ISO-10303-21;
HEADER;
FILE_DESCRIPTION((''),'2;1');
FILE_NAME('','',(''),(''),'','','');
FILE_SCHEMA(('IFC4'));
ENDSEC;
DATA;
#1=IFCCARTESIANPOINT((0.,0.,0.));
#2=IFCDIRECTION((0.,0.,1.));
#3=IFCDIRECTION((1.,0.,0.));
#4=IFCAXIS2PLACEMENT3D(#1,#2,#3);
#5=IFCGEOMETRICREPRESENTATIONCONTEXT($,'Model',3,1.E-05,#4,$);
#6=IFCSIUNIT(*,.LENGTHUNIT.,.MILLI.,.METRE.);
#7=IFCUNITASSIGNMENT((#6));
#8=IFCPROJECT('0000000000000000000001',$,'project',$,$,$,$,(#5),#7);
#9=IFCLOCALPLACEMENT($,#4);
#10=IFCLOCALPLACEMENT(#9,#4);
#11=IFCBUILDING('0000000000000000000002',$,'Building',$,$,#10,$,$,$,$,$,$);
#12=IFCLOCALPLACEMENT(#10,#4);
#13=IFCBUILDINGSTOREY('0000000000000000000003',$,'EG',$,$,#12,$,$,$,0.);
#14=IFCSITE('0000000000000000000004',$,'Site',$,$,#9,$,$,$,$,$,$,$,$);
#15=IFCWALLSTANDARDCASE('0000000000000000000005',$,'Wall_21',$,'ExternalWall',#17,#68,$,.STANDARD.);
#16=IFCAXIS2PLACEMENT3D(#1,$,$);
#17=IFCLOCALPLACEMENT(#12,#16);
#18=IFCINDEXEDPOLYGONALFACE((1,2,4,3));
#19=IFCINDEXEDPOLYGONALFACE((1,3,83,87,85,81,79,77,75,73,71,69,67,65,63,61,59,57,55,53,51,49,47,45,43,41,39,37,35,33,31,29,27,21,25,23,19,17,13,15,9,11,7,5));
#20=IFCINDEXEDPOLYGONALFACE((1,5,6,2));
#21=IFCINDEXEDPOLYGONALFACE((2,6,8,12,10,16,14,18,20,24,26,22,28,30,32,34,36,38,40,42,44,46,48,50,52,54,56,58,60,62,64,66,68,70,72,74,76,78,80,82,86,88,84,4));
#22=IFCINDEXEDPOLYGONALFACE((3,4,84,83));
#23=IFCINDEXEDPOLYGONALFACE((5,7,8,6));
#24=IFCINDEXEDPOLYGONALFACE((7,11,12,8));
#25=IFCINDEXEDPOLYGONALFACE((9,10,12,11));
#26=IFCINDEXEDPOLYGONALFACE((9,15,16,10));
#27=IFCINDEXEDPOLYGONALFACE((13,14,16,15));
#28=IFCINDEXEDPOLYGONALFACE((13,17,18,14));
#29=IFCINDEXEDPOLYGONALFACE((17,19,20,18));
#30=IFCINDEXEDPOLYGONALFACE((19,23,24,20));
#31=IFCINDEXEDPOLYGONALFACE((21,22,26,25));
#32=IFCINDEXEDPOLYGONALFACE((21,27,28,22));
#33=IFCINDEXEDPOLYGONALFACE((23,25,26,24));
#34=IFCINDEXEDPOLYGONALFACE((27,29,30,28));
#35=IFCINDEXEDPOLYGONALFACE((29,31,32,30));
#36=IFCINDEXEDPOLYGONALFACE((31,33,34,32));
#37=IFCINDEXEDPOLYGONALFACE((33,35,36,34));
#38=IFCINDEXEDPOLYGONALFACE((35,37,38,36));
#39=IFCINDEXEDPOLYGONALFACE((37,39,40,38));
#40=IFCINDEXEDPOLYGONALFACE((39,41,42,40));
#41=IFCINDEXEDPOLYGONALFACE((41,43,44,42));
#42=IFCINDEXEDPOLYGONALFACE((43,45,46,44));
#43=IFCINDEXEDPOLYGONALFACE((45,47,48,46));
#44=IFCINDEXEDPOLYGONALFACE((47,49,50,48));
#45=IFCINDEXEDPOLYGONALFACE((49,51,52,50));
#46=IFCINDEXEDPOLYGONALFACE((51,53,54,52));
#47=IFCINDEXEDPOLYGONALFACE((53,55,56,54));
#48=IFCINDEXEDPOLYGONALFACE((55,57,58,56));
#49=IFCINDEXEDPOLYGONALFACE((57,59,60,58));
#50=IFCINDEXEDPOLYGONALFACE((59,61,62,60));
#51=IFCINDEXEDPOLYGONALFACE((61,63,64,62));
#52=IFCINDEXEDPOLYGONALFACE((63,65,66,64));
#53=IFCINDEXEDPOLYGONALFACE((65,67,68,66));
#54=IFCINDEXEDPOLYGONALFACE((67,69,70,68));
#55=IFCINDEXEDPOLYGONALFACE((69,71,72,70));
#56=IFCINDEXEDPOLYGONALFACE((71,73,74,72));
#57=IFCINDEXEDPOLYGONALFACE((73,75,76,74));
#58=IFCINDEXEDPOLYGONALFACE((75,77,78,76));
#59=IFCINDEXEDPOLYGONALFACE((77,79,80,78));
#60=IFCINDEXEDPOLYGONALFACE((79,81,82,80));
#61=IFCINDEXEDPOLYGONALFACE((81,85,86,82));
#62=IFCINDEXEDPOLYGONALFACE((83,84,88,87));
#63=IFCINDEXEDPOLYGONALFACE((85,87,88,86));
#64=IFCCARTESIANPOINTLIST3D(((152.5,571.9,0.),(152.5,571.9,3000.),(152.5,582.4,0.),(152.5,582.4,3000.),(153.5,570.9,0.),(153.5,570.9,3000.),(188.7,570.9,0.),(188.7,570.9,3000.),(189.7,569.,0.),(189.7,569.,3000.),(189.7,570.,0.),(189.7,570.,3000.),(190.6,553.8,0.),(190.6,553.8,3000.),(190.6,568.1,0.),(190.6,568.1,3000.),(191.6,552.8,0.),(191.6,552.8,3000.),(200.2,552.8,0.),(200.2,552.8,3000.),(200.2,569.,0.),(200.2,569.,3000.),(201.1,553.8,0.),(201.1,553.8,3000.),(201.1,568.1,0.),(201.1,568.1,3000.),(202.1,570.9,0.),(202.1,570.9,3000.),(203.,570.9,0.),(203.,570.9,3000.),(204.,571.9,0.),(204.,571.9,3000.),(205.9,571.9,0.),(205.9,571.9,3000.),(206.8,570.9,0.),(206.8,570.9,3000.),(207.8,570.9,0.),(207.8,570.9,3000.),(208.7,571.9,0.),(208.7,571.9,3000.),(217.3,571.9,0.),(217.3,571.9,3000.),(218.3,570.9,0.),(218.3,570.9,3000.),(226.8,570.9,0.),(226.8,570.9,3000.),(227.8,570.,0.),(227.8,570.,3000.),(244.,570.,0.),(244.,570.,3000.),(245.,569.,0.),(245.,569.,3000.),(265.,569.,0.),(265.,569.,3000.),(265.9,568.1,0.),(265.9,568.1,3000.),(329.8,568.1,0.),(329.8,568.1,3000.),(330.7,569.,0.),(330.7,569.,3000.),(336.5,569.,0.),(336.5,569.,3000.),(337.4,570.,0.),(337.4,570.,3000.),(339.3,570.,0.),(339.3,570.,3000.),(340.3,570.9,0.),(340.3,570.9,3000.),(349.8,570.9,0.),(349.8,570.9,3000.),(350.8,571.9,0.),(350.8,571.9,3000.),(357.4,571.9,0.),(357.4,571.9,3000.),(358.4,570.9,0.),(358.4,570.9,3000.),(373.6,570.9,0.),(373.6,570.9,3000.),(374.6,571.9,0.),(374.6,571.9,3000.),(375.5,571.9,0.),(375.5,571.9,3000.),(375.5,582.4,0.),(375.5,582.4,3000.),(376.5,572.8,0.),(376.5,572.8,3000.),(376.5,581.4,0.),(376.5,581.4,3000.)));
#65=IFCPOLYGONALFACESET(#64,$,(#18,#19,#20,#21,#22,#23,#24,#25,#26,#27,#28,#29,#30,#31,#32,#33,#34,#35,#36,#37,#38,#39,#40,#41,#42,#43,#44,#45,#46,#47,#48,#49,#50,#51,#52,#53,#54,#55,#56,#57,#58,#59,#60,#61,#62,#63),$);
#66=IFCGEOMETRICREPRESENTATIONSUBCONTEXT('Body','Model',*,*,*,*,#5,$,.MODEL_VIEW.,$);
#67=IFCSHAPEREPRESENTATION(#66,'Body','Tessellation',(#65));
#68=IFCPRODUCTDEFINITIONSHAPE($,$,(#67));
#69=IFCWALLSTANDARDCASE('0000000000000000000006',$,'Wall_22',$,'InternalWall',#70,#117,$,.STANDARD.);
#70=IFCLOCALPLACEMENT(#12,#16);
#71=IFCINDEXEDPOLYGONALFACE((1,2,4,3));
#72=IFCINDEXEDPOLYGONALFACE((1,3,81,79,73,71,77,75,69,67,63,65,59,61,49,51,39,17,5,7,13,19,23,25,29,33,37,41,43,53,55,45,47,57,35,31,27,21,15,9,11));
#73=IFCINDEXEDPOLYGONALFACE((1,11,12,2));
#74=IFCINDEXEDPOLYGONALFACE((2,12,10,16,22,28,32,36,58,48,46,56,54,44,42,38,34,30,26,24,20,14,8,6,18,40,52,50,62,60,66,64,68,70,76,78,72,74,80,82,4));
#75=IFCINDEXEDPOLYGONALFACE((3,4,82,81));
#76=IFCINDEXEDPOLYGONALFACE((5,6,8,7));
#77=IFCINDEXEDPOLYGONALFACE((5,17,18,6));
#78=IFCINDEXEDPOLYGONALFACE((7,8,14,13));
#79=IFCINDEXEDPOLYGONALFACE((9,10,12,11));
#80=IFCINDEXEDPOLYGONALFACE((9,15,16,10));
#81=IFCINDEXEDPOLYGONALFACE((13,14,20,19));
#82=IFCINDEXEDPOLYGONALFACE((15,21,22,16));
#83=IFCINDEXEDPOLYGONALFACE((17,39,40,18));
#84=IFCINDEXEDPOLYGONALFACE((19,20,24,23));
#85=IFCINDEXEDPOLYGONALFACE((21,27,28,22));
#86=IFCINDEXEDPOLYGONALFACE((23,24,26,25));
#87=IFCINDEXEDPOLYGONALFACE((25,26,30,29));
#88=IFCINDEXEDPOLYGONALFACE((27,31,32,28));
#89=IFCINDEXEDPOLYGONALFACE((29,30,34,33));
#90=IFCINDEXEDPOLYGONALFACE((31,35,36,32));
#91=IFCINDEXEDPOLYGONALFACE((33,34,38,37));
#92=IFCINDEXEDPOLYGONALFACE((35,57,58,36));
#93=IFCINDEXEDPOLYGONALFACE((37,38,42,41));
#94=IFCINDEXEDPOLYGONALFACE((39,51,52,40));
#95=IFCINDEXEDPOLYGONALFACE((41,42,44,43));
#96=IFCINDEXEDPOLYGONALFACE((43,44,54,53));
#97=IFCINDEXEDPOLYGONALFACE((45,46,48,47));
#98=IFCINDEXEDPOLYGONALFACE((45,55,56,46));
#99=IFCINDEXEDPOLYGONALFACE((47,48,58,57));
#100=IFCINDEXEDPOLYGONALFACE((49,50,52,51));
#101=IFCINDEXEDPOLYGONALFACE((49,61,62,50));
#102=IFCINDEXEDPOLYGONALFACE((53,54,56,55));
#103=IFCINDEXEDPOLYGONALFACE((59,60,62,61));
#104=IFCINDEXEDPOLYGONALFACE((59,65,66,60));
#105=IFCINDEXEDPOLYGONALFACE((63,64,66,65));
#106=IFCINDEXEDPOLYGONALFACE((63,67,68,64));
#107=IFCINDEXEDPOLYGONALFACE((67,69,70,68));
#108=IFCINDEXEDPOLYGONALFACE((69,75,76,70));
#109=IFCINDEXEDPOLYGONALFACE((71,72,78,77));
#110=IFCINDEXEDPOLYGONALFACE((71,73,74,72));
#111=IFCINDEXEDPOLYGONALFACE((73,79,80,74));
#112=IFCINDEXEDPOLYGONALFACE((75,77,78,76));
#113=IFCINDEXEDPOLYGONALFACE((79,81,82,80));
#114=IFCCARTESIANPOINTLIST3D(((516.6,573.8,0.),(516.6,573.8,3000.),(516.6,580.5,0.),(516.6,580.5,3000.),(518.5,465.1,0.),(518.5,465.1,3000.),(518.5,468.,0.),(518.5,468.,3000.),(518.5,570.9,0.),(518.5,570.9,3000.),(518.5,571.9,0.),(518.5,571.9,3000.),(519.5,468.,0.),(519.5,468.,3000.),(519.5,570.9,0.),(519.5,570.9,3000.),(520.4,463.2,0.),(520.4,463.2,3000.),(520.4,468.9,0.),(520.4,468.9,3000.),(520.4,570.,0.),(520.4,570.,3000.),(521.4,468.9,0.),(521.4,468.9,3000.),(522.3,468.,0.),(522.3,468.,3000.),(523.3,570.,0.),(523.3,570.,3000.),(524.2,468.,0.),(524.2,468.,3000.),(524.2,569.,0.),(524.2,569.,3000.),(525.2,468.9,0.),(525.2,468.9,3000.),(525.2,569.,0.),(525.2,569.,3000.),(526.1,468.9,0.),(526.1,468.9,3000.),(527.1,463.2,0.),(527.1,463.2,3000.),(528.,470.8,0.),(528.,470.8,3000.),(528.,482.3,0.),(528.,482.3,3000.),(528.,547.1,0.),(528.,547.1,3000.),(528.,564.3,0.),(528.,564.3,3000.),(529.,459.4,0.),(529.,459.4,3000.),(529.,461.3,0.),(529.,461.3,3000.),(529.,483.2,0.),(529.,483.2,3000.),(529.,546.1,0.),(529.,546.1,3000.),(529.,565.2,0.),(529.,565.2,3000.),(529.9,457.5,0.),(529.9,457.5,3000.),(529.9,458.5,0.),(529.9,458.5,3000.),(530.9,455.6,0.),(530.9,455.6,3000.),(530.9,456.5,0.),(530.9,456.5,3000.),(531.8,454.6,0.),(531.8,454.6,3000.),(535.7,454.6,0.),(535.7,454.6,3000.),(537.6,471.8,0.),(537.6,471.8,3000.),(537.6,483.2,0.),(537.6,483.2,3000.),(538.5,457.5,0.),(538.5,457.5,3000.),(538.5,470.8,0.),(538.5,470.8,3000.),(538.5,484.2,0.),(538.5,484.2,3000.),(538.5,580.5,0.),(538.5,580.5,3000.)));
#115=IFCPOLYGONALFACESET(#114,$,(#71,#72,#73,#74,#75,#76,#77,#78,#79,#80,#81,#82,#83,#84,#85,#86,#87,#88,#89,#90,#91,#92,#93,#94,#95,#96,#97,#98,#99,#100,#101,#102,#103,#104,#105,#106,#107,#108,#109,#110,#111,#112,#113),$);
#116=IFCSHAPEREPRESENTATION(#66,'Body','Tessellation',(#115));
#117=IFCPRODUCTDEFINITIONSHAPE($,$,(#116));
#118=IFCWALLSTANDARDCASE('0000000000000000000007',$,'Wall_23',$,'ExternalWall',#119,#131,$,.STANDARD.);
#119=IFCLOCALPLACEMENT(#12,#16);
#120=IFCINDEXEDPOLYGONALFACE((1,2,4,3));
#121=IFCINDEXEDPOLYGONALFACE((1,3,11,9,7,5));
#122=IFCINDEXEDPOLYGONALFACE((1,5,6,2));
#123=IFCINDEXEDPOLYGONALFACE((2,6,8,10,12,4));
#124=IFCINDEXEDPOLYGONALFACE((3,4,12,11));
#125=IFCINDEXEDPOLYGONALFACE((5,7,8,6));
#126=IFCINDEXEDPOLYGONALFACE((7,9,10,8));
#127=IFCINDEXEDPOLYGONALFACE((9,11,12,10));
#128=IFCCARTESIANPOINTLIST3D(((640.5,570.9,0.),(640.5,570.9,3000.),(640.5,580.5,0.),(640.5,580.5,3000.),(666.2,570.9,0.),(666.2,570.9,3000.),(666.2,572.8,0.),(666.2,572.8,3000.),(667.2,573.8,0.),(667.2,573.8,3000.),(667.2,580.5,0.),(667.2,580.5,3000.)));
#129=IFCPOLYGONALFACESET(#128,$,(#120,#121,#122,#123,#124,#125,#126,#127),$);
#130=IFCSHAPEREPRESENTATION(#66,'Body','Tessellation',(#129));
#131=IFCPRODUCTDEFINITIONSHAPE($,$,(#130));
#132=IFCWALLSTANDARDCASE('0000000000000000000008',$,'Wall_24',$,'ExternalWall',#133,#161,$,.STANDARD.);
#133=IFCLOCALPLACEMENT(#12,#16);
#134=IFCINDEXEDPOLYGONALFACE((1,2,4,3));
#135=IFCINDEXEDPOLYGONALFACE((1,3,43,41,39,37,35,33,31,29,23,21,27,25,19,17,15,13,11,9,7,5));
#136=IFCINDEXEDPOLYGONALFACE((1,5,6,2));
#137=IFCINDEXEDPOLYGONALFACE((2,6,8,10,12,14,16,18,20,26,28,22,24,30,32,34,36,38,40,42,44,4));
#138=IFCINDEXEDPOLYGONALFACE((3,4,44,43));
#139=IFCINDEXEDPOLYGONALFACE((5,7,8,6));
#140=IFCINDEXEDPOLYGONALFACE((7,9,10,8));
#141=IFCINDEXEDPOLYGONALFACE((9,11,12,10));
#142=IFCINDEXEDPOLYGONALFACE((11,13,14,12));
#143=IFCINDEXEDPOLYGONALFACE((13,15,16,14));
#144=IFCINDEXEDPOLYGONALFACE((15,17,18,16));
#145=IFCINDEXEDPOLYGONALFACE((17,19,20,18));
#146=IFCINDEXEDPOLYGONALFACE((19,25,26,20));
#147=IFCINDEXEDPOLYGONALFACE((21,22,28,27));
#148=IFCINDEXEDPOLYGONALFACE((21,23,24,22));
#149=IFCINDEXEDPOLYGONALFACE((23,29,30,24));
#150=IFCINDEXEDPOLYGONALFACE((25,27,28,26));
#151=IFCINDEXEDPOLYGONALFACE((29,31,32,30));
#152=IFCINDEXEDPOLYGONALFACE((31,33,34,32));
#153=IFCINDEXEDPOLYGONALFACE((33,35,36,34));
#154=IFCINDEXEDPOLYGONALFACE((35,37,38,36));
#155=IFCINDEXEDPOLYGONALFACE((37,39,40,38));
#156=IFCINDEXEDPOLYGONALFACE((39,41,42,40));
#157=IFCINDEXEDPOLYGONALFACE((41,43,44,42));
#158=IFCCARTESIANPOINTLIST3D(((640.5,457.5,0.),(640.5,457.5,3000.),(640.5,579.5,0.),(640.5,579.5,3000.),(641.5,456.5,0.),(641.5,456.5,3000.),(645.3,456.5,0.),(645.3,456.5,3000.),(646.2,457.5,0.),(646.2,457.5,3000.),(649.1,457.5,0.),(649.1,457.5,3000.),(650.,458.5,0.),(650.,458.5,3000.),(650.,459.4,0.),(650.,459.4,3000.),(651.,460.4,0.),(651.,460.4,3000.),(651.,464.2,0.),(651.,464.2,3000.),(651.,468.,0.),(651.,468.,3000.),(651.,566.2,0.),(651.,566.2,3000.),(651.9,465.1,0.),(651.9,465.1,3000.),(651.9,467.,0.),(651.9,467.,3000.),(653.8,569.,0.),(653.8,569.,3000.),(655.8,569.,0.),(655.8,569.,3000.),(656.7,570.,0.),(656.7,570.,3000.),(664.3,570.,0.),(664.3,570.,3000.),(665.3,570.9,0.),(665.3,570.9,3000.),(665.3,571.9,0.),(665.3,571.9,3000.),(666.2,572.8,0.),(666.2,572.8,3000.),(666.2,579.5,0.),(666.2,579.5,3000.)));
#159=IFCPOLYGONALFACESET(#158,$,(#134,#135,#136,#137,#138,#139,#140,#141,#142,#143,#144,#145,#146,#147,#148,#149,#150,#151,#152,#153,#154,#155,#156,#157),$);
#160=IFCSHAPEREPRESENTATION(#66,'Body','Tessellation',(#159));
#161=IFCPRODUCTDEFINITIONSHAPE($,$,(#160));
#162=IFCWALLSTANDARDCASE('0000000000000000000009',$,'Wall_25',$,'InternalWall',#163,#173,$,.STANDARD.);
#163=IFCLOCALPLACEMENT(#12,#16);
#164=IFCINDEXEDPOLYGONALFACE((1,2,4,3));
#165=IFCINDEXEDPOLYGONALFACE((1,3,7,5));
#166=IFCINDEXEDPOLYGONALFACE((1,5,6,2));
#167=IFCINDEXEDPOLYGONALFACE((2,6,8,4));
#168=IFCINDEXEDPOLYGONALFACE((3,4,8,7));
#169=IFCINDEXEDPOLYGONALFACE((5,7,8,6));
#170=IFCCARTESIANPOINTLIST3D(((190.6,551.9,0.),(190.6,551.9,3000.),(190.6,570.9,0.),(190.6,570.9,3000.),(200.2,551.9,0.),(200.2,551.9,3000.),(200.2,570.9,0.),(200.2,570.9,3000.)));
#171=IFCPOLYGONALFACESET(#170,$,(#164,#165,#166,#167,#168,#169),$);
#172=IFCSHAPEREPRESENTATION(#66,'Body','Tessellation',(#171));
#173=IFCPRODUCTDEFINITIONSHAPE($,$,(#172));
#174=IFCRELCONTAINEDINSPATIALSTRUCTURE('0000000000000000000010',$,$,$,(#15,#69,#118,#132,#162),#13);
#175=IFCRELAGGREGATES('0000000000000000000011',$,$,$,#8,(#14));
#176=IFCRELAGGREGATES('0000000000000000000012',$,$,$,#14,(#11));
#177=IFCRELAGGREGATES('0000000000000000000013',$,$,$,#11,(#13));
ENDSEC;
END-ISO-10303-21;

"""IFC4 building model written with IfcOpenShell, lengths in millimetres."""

from ifc_helpers import new_model, si_unit, origin_with_axes, place, context, subcontext, project, spatial, polyline, outline, extrude, element, save


model = new_model("IFC4")

# Units and contexts
model_context = context("Model", 3, precision=1e-05, world=origin_with_axes())
body_context = subcontext(model_context, "Body", "Model", "MODEL_VIEW")
ifc_project = project(units=[si_unit("LENGTHUNIT", "METRE", prefix="MILLI")], contexts=[model_context])

# Site, building, storey
site_placement = place(None, origin_with_axes())
site = spatial("IfcSite", under=ifc_project, at=site_placement, Name="Site")
building_placement = place(site_placement, origin_with_axes())
building = spatial("IfcBuilding", under=site, at=building_placement, Name="Building")
storey_placement = place(building_placement, origin_with_axes())
storey = spatial("IfcBuildingStorey", under=building, at=storey_placement, Name="EG", Elevation=0.0)

# Walls
wall_1_placement = place(storey_placement, origin_with_axes())
element("IfcWallStandardCase", 1, at=wall_1_placement, inside=storey, Name="Wall_21", ObjectType="ExternalWall", PredefinedType="STANDARD", context=body_context, shape_type="SweptSolid", body=[
    extrude(outline(polyline([(191.6, 552.8, 0.0), (190.6, 553.8, 0.0), (190.6, 568.1, 0.0), (189.7, 569.0, 0.0), (189.7, 570.0, 0.0), (188.7, 570.9, 0.0), (153.5, 570.9, 0.0), (152.5, 571.9, 0.0), (152.5, 582.4, 0.0), (375.5, 582.4, 0.0), (376.5, 581.4, 0.0), (376.5, 572.8, 0.0), (375.5, 571.9, 0.0), (374.6, 571.9, 0.0), (373.6, 570.9, 0.0), (358.4, 570.9, 0.0), (357.4, 571.9, 0.0), (350.8, 571.9, 0.0), (349.8, 570.9, 0.0), (340.3, 570.9, 0.0), (339.3, 570.0, 0.0), (337.4, 570.0, 0.0), (336.5, 569.0, 0.0), (330.7, 569.0, 0.0), (329.8, 568.1, 0.0), (265.9, 568.1, 0.0), (265.0, 569.0, 0.0), (245.0, 569.0, 0.0), (244.0, 570.0, 0.0), (227.8, 570.0, 0.0), (226.8, 570.9, 0.0), (218.3, 570.9, 0.0), (217.3, 571.9, 0.0), (208.7, 571.9, 0.0), (207.8, 570.9, 0.0), (206.8, 570.9, 0.0), (205.9, 571.9, 0.0), (204.0, 571.9, 0.0), (203.0, 570.9, 0.0), (202.1, 570.9, 0.0), (200.2, 569.0, 0.0), (201.1, 568.1, 0.0), (201.1, 553.8, 0.0), (200.2, 552.8, 0.0), (191.6, 552.8, 0.0)])), origin_with_axes(), (0.0, 0.0, 1.0), 3000.0),
])
wall_2_placement = place(storey_placement, origin_with_axes())
element("IfcWallStandardCase", 2, at=wall_2_placement, inside=storey, Name="Wall_22", ObjectType="InternalWall", PredefinedType="STANDARD", context=body_context, shape_type="SweptSolid", body=[
    extrude(outline(polyline([(531.8, 454.6, 0.0), (530.9, 455.6, 0.0), (530.9, 456.5, 0.0), (529.9, 457.5, 0.0), (529.9, 458.5, 0.0), (529.0, 459.4, 0.0), (529.0, 461.3, 0.0), (527.1, 463.2, 0.0), (520.4, 463.2, 0.0), (518.5, 465.1, 0.0), (518.5, 468.0, 0.0), (519.5, 468.0, 0.0), (520.4, 468.9, 0.0), (521.4, 468.9, 0.0), (522.3, 468.0, 0.0), (524.2, 468.0, 0.0), (525.2, 468.9, 0.0), (526.1, 468.9, 0.0), (528.0, 470.8, 0.0), (528.0, 482.3, 0.0), (529.0, 483.2, 0.0), (529.0, 546.1, 0.0), (528.0, 547.1, 0.0), (528.0, 564.3, 0.0), (529.0, 565.2, 0.0), (525.2, 569.0, 0.0), (524.2, 569.0, 0.0), (523.3, 570.0, 0.0), (520.4, 570.0, 0.0), (519.5, 570.9, 0.0), (518.5, 570.9, 0.0), (518.5, 571.9, 0.0), (516.6, 573.8, 0.0), (516.6, 580.5, 0.0), (538.5, 580.5, 0.0), (538.5, 484.2, 0.0), (537.6, 483.2, 0.0), (537.6, 471.8, 0.0), (538.5, 470.8, 0.0), (538.5, 457.5, 0.0), (535.7, 454.6, 0.0), (531.8, 454.6, 0.0)])), origin_with_axes(), (0.0, 0.0, 1.0), 3000.0),
])
wall_3_placement = place(storey_placement, origin_with_axes())
element("IfcWallStandardCase", 3, at=wall_3_placement, inside=storey, Name="Wall_23", ObjectType="ExternalWall", PredefinedType="STANDARD", context=body_context, shape_type="SweptSolid", body=[
    extrude(outline(polyline([(640.5, 570.9, 0.0), (640.5, 580.5, 0.0), (667.2, 580.5, 0.0), (667.2, 573.8, 0.0), (666.2, 572.8, 0.0), (666.2, 570.9, 0.0), (640.5, 570.9, 0.0)])), origin_with_axes(), (0.0, 0.0, 1.0), 3000.0),
])
wall_4_placement = place(storey_placement, origin_with_axes())
element("IfcWallStandardCase", 4, at=wall_4_placement, inside=storey, Name="Wall_24", ObjectType="ExternalWall", PredefinedType="STANDARD", context=body_context, shape_type="SweptSolid", body=[
    extrude(outline(polyline([(641.5, 456.5, 0.0), (640.5, 457.5, 0.0), (640.5, 579.5, 0.0), (666.2, 579.5, 0.0), (666.2, 572.8, 0.0), (665.3, 571.9, 0.0), (665.3, 570.9, 0.0), (664.3, 570.0, 0.0), (656.7, 570.0, 0.0), (655.8, 569.0, 0.0), (653.8, 569.0, 0.0), (651.0, 566.2, 0.0), (651.0, 468.0, 0.0), (651.9, 467.0, 0.0), (651.9, 465.1, 0.0), (651.0, 464.2, 0.0), (651.0, 460.4, 0.0), (650.0, 459.4, 0.0), (650.0, 458.5, 0.0), (649.1, 457.5, 0.0), (646.2, 457.5, 0.0), (645.3, 456.5, 0.0), (641.5, 456.5, 0.0)])), origin_with_axes(), (0.0, 0.0, 1.0), 3000.0),
])
wall_5_placement = place(storey_placement, origin_with_axes())
element("IfcWallStandardCase", 5, at=wall_5_placement, inside=storey, Name="Wall_25", ObjectType="InternalWall", PredefinedType="STANDARD", context=body_context, shape_type="SweptSolid", body=[
    extrude(outline(polyline([(190.6, 551.9, 0.0), (190.6, 570.9, 0.0), (200.2, 570.9, 0.0), (200.2, 551.9, 0.0), (190.6, 551.9, 0.0)])), origin_with_axes(), (0.0, 0.0, 1.0), 3000.0),
])

save(model, "model.ifc")
